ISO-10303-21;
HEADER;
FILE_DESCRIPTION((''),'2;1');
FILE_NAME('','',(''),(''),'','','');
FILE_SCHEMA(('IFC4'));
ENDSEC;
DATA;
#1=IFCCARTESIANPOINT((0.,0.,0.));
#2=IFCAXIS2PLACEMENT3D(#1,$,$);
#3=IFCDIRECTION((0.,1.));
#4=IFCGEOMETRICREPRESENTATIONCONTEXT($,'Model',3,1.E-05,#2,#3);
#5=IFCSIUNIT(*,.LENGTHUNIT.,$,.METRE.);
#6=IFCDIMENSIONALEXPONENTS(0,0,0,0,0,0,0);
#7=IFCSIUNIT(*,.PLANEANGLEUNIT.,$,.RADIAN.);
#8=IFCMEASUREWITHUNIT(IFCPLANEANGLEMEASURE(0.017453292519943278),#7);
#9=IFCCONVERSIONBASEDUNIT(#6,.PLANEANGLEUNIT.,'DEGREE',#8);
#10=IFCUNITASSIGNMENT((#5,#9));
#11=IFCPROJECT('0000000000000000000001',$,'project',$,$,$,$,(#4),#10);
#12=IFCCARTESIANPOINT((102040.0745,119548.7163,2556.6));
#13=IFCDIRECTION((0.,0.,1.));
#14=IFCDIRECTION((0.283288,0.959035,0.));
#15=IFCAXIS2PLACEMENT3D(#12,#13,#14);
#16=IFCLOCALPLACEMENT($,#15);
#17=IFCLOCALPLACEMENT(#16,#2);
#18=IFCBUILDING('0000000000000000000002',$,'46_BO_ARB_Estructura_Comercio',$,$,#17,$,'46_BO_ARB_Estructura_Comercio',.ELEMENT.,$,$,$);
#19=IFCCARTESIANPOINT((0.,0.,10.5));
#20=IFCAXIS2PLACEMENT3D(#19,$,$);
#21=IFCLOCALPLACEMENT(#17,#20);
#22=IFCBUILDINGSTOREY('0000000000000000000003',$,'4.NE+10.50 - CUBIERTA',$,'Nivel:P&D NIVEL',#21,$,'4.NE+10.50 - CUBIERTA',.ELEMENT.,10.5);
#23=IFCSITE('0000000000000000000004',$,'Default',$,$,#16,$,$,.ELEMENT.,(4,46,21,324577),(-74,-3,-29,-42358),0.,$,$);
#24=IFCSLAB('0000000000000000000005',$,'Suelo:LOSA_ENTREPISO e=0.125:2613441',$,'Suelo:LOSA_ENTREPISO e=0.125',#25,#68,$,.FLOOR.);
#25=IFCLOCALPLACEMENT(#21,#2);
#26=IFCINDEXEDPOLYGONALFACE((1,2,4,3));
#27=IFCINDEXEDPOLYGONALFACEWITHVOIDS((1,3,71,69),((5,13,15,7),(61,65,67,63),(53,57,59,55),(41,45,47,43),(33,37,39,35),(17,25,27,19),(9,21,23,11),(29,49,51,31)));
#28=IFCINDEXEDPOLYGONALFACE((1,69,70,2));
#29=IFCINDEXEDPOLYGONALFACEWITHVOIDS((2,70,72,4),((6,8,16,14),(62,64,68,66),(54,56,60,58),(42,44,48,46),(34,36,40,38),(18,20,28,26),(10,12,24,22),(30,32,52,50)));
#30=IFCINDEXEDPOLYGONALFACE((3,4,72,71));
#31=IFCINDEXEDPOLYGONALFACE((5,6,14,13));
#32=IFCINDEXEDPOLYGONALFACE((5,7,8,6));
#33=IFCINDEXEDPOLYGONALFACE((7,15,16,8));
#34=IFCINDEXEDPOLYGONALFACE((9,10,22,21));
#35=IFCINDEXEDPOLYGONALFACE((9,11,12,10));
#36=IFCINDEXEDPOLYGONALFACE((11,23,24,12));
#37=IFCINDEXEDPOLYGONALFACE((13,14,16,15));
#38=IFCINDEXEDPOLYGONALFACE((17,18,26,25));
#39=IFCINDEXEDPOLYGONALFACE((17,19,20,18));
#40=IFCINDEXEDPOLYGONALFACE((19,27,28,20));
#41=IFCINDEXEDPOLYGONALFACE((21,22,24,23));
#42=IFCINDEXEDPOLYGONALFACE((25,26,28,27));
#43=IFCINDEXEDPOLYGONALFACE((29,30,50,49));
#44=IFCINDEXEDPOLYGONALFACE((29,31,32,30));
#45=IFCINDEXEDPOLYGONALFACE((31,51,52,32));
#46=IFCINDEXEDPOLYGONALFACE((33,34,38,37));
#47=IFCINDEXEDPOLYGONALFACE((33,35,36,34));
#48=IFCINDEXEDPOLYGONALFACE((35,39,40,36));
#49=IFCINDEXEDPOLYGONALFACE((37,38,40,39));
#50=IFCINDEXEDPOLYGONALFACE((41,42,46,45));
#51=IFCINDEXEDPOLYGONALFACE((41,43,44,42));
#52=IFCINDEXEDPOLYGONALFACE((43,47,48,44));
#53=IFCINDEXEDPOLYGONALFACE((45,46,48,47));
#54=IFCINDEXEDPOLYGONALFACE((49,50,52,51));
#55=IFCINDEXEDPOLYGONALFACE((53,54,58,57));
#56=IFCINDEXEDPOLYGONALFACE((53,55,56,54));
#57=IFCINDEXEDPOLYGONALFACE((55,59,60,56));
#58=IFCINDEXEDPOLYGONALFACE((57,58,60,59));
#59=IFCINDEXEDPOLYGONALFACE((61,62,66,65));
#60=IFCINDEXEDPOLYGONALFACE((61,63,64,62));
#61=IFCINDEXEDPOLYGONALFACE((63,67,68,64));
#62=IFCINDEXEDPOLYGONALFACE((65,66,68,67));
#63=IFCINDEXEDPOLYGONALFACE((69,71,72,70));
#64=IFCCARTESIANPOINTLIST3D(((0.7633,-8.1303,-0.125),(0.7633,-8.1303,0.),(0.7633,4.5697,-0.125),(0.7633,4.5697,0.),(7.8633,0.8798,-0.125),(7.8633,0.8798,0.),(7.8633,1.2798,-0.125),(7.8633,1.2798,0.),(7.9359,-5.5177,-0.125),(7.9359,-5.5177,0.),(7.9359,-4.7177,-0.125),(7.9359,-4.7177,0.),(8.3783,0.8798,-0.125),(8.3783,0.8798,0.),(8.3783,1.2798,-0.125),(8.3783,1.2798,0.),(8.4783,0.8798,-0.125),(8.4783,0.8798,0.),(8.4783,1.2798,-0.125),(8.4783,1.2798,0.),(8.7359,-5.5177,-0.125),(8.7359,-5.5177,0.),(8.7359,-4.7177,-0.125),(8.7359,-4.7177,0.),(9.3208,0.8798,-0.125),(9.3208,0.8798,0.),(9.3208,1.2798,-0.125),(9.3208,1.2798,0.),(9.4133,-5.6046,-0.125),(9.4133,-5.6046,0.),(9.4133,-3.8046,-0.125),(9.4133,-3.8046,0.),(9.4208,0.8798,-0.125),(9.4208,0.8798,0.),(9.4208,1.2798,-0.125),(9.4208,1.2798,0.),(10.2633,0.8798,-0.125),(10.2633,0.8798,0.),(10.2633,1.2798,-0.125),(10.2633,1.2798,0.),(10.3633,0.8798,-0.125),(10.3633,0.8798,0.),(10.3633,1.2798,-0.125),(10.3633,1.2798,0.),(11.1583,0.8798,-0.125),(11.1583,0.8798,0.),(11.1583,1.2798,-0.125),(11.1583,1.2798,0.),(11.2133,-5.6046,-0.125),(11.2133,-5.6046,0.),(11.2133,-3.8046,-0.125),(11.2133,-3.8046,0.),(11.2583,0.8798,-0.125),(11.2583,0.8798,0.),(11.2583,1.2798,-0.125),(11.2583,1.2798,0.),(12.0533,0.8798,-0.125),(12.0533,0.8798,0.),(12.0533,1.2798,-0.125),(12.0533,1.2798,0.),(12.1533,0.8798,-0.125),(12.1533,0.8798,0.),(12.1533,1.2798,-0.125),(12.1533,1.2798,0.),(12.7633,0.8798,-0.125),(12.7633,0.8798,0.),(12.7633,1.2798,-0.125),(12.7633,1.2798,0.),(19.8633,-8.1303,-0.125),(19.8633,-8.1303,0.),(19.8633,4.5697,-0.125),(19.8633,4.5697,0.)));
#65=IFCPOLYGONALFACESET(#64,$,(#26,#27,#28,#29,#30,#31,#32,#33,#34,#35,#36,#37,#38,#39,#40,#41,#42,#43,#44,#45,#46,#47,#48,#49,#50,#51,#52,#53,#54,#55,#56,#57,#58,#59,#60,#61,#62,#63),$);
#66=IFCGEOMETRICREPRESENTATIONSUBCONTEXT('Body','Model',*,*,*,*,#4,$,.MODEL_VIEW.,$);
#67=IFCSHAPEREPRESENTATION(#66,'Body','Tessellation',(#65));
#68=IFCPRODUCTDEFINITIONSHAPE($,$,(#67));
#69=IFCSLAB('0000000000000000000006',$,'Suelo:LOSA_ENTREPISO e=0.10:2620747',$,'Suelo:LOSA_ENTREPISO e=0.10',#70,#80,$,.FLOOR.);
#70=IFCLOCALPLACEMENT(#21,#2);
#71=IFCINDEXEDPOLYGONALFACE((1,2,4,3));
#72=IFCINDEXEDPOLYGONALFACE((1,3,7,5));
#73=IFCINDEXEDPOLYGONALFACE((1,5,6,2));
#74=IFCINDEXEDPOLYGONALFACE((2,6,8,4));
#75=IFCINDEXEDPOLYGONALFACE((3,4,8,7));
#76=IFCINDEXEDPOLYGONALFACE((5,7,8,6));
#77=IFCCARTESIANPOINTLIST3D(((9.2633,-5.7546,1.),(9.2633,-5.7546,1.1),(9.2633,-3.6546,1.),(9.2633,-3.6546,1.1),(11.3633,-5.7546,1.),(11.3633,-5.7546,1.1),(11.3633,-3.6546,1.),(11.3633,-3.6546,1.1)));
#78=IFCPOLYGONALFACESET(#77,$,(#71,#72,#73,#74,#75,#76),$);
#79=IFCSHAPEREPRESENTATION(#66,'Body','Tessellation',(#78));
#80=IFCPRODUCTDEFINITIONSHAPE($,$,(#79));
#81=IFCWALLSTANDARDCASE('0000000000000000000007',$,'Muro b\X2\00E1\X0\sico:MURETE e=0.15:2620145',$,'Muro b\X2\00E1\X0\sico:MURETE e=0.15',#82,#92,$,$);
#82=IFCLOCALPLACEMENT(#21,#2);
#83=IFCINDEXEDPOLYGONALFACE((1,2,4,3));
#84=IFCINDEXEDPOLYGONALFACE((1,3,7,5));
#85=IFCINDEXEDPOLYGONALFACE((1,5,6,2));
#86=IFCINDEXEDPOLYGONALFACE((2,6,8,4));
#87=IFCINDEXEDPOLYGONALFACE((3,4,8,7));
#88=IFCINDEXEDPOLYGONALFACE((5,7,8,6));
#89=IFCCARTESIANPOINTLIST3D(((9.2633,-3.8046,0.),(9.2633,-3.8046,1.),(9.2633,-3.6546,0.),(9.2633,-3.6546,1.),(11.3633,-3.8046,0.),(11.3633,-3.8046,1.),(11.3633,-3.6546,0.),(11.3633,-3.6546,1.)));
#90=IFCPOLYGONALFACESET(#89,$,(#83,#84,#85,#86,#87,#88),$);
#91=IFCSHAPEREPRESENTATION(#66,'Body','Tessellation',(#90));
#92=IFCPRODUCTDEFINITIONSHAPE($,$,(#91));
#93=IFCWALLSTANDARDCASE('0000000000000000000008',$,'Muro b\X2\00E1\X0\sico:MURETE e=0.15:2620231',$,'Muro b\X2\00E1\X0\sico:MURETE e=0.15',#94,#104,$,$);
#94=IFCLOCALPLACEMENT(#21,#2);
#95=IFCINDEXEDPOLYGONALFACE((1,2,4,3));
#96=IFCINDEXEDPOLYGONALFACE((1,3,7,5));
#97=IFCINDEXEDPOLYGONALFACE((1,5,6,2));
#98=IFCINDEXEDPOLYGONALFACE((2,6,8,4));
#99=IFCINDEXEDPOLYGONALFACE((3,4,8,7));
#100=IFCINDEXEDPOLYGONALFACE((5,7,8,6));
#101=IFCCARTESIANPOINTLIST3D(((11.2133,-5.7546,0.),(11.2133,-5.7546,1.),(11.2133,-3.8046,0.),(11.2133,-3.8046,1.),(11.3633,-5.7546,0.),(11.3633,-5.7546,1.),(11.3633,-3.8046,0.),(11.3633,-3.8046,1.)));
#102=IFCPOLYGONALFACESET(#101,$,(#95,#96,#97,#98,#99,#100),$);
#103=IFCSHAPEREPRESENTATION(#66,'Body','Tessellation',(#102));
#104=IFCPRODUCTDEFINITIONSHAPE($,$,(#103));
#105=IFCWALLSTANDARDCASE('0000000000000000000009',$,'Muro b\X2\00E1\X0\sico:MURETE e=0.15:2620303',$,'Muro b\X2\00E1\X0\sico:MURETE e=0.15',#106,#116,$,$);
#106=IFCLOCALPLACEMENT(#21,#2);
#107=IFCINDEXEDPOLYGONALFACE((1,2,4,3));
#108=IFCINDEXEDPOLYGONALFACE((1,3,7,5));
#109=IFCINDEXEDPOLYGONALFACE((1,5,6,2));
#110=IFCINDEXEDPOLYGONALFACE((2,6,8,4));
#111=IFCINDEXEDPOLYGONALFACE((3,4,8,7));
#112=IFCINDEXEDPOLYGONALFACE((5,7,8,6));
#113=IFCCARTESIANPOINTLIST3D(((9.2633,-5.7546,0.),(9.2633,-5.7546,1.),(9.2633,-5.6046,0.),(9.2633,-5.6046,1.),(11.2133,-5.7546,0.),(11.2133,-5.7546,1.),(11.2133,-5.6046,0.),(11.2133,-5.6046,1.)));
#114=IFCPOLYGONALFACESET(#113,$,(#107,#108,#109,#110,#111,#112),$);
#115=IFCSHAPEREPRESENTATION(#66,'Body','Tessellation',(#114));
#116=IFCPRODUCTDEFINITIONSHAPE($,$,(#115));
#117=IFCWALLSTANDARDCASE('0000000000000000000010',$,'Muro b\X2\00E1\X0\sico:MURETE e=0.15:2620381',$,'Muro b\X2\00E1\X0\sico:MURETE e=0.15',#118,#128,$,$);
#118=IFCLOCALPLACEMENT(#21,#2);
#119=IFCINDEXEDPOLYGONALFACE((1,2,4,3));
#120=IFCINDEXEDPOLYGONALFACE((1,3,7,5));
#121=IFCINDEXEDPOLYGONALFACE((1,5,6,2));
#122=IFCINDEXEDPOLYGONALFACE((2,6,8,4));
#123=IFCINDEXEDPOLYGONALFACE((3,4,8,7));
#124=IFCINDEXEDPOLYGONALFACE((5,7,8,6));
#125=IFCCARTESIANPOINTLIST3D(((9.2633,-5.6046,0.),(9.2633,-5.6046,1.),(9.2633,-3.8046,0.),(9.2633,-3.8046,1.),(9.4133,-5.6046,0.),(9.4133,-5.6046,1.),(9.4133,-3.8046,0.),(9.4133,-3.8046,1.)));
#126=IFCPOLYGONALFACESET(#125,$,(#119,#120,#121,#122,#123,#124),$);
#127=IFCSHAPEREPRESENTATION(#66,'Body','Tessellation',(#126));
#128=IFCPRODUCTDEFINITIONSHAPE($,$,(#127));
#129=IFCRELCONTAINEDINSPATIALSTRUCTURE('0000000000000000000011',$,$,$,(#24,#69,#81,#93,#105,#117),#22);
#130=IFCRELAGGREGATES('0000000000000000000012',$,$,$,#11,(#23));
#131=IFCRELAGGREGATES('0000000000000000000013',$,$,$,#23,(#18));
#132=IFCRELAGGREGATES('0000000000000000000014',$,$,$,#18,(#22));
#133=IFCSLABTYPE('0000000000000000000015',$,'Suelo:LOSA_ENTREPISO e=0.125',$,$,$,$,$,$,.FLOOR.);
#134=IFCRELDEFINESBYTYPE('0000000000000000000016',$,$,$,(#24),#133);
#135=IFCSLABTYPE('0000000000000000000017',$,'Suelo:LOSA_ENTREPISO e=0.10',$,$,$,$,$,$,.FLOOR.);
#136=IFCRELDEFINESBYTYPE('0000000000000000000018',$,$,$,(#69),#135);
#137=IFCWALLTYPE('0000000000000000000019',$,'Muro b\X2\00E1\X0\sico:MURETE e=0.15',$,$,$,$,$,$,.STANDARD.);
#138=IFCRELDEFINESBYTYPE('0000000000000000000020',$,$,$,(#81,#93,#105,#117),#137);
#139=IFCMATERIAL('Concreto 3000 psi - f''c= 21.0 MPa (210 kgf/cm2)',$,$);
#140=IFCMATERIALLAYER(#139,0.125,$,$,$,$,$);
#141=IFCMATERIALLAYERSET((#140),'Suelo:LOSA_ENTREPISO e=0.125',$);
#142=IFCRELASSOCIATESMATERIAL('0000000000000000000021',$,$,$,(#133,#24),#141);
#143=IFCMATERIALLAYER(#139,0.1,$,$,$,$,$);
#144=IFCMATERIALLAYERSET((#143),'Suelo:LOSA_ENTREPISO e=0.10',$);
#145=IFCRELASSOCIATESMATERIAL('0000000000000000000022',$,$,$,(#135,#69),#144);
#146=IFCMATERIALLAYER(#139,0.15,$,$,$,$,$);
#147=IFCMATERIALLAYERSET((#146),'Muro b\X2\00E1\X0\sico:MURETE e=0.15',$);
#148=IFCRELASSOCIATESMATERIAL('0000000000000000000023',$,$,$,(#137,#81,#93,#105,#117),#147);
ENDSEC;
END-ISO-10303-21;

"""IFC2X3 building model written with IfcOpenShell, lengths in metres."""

from ifc_helpers import new_model, entity, si_unit, converted_unit, direction, frame, frame_2d, origin, origin_2d_with_axis, place, context, subcontext, project, spatial, rectangle, extrude, boolean, material, layer, layer_set, layer_usage, type_object, element, save


model = new_model("IFC2X3")

# Units and contexts
model_context = context("Model", 3, precision=1e-05, world=origin(), true_north=direction((0.0, 1.0)))
body_context = subcontext(model_context, "Body", "Model", "MODEL_VIEW")
ifc_project = project(units=[si_unit("LENGTHUNIT", "METRE"), converted_unit("PLANEANGLEUNIT", "DEGREE", entity("IfcPlaneAngleMeasure", 0.017453292519943278), si_unit("PLANEANGLEUNIT", "RADIAN"), dimensions=[0, 0, 0, 0, 0, 0, 0])], contexts=[model_context])

# Site, building, storey
site_placement = place(None, frame((102040.0745, 119548.7163, 2556.6), z_axis=(0.0, 0.0, 1.0), x_axis=(0.283288, 0.959035, 0.0)))
site = spatial("IfcSite", under=ifc_project, at=site_placement, Name="Default", CompositionType="ELEMENT", RefLatitude=(4, 46, 21, 324577), RefLongitude=(-74, -3, -29, -42358), RefElevation=0.0)
building_placement = place(site_placement, origin())
building = spatial("IfcBuilding", under=site, at=building_placement, Name="46_BO_ARB_Estructura_Comercio", LongName="46_BO_ARB_Estructura_Comercio", CompositionType="ELEMENT")
storey_placement = place(building_placement, frame((0.0, 0.0, 10.5)))
storey = spatial("IfcBuildingStorey", under=building, at=storey_placement, Name="4.NE+10.50 - CUBIERTA", ObjectType="Nivel:P&D NIVEL", LongName="4.NE+10.50 - CUBIERTA", CompositionType="ELEMENT", Elevation=10.5)

# Shared definitions
ifc_material = material(Name="Concreto 3000 psi - f'c= 21.0 MPa (210 kgf/cm2)")

# Slab, openings
ifc_layer_1 = layer(ifc_material, 0.125)
ifc_layer_set_1 = layer_set([ifc_layer_1], Name="Suelo:LOSA_ENTREPISO e=0.125")
ifc_layer_usage_1 = layer_usage(ifc_layer_set_1, "AXIS3", "POSITIVE", 0.0)
slab_type_1 = type_object("IfcSlabType", Name="Suelo:LOSA_ENTREPISO e=0.125", PredefinedType="FLOOR", material=ifc_layer_set_1)
slab_1_placement = place(storey_placement, origin())
slab_1 = element("IfcSlab", 1, at=slab_1_placement, inside=storey, type_object=slab_type_1, material=ifc_layer_usage_1, Name="Suelo:LOSA_ENTREPISO e=0.125:2613441", ObjectType="Suelo:LOSA_ENTREPISO e=0.125", PredefinedType="FLOOR", context=body_context, shape_type="SweptSolid", body=[
    boolean("DIFFERENCE", boolean("DIFFERENCE", boolean("DIFFERENCE", boolean("DIFFERENCE", boolean("DIFFERENCE", boolean("DIFFERENCE", boolean("DIFFERENCE", boolean("DIFFERENCE", extrude(rectangle(XDim=12.7, YDim=19.1, at=origin_2d_with_axis()), frame((10.3133, -1.7803, 0.0), z_axis=(0.0, 0.0, -1.0), x_axis=(0.0, 1.0, 0.0)), (0.0, 0.0, 1.0), 0.125), extrude(rectangle(XDim=0.4, YDim=0.515, at=origin_2d_with_axis()), frame((8.1208, 1.0798, -0.125), z_axis=(0.0, 0.0, 1.0), x_axis=(0.0, 1.0, 0.0)), (0.0, 0.0, 1.0), 0.125)), extrude(rectangle(XDim=0.4, YDim=0.8425, at=origin_2d_with_axis()), frame((8.8995, 1.0798, -0.125), z_axis=(0.0, 0.0, 1.0), x_axis=(0.0, 1.0, 0.0)), (0.0, 0.0, 1.0), 0.125)), extrude(rectangle(XDim=0.4, YDim=0.8425, at=origin_2d_with_axis()), frame((9.842, 1.0798, -0.125), z_axis=(0.0, 0.0, 1.0), x_axis=(0.0, 1.0, 0.0)), (0.0, 0.0, 1.0), 0.125)), extrude(rectangle(XDim=0.4, YDim=0.795, at=frame_2d((0.0, 0.0), x_axis=(1.0, 0.0))), frame((10.7608, 1.0798, -0.125), z_axis=(0.0, 0.0, 1.0), x_axis=(0.0, 1.0, 0.0)), (0.0, 0.0, 1.0), 0.125)), extrude(rectangle(XDim=1.8, YDim=1.8, at=origin_2d_with_axis()), frame((10.3133, -4.7046, -0.125), z_axis=(0.0, 0.0, 1.0), x_axis=(0.0, 1.0, 0.0)), (0.0, 0.0, 1.0), 0.125)), extrude(rectangle(XDim=0.4, YDim=0.795, at=frame_2d((0.0, 0.0), x_axis=(1.0, 0.0))), frame((11.6558, 1.0798, -0.125), z_axis=(0.0, 0.0, 1.0), x_axis=(0.0, 1.0, 0.0)), (0.0, 0.0, 1.0), 0.125)), extrude(rectangle(XDim=0.4, YDim=0.61, at=frame_2d((0.0, 0.0), x_axis=(1.0, 0.0))), frame((12.4583, 1.0798, -0.125), z_axis=(0.0, 0.0, 1.0), x_axis=(0.0, 1.0, 0.0)), (0.0, 0.0, 1.0), 0.125)), extrude(rectangle(XDim=0.8, YDim=0.8, at=origin_2d_with_axis()), frame((8.3359, -5.1177, -0.125), z_axis=(0.0, 0.0, 1.0), x_axis=(0.0, 1.0, 0.0)), (0.0, 0.0, 1.0), 0.125)),
])
opening_1_placement = place(slab_1_placement, origin())
element("IfcOpeningElement", 2, at=opening_1_placement, cuts=slab_1, ObjectType="Opening", context=body_context, shape_type="SweptSolid", body=[
    extrude(rectangle(XDim=0.515, YDim=0.4, at=origin_2d_with_axis()), frame((8.1208, 1.0798, 0.0), z_axis=(0.0, 0.0, -1.0), x_axis=(-1.0, 0.0, 0.0)), (0.0, 0.0, 1.0), 0.125),
])
opening_2_placement = place(slab_1_placement, origin())
element("IfcOpeningElement", 3, at=opening_2_placement, cuts=slab_1, ObjectType="Opening", context=body_context, shape_type="SweptSolid", body=[
    extrude(rectangle(XDim=0.4, YDim=0.8425, at=frame_2d((0.0, 0.0), x_axis=(1.0, 0.0))), frame((8.8995, 1.0798, 0.0), z_axis=(0.0, 0.0, -1.0), x_axis=(0.0, -1.0, 0.0)), (0.0, 0.0, 1.0), 0.125),
])
opening_3_placement = place(slab_1_placement, origin())
element("IfcOpeningElement", 4, at=opening_3_placement, cuts=slab_1, ObjectType="Opening", context=body_context, shape_type="SweptSolid", body=[
    extrude(rectangle(XDim=0.4, YDim=0.8425, at=origin_2d_with_axis()), frame((9.842, 1.0798, 0.0), z_axis=(0.0, 0.0, -1.0), x_axis=(0.0, -1.0, 0.0)), (0.0, 0.0, 1.0), 0.125),
])
opening_4_placement = place(slab_1_placement, origin())
element("IfcOpeningElement", 5, at=opening_4_placement, cuts=slab_1, ObjectType="Opening", context=body_context, shape_type="SweptSolid", body=[
    extrude(rectangle(XDim=0.4, YDim=0.795, at=frame_2d((0.0, 0.0), x_axis=(1.0, 0.0))), frame((10.7608, 1.0798, 0.0), z_axis=(0.0, 0.0, -1.0), x_axis=(0.0, -1.0, 0.0)), (0.0, 0.0, 1.0), 0.125),
])
opening_5_placement = place(slab_1_placement, origin())
element("IfcOpeningElement", 6, at=opening_5_placement, cuts=slab_1, ObjectType="Opening", context=body_context, shape_type="SweptSolid", body=[
    extrude(rectangle(XDim=0.4, YDim=0.795, at=frame_2d((0.0, 0.0), x_axis=(1.0, 0.0))), frame((11.6558, 1.0798, 0.0), z_axis=(0.0, 0.0, -1.0), x_axis=(0.0, -1.0, 0.0)), (0.0, 0.0, 1.0), 0.125),
])
opening_6_placement = place(slab_1_placement, origin())
element("IfcOpeningElement", 7, at=opening_6_placement, cuts=slab_1, ObjectType="Opening", context=body_context, shape_type="SweptSolid", body=[
    extrude(rectangle(XDim=0.4, YDim=0.61, at=frame_2d((0.0, 0.0), x_axis=(1.0, 0.0))), frame((12.4583, 1.0798, 0.0), z_axis=(0.0, 0.0, -1.0), x_axis=(0.0, -1.0, 0.0)), (0.0, 0.0, 1.0), 0.125),
])
opening_7_placement = place(slab_1_placement, origin())
element("IfcOpeningElement", 8, at=opening_7_placement, cuts=slab_1, ObjectType="Opening", context=body_context, shape_type="SweptSolid", body=[
    extrude(rectangle(XDim=1.8, YDim=1.8, at=frame_2d((0.0, 0.0), x_axis=(1.0, 0.0))), frame((10.3133, -4.7046, 0.0), z_axis=(0.0, 0.0, -1.0), x_axis=(0.0, -1.0, 0.0)), (0.0, 0.0, 1.0), 0.125),
])
opening_8_placement = place(slab_1_placement, origin())
element("IfcOpeningElement", 9, at=opening_8_placement, cuts=slab_1, ObjectType="Opening", context=body_context, shape_type="SweptSolid", body=[
    extrude(rectangle(XDim=0.8, YDim=0.8, at=origin_2d_with_axis()), frame((8.3359, -5.1177, 0.0), z_axis=(0.0, 0.0, -1.0), x_axis=(0.0, -1.0, 0.0)), (0.0, 0.0, 1.0), 0.125),
])

# Slab
ifc_layer_2 = layer(ifc_material, 0.1)
ifc_layer_set_2 = layer_set([ifc_layer_2], Name="Suelo:LOSA_ENTREPISO e=0.10")
ifc_layer_usage_2 = layer_usage(ifc_layer_set_2, "AXIS3", "POSITIVE", 0.0)
slab_type_2 = type_object("IfcSlabType", Name="Suelo:LOSA_ENTREPISO e=0.10", PredefinedType="FLOOR", material=ifc_layer_set_2)
slab_2_placement = place(storey_placement, origin())
element("IfcSlab", 10, at=slab_2_placement, inside=storey, type_object=slab_type_2, material=ifc_layer_usage_2, Name="Suelo:LOSA_ENTREPISO e=0.10:2620747", ObjectType="Suelo:LOSA_ENTREPISO e=0.10", PredefinedType="FLOOR", context=body_context, shape_type="SweptSolid", body=[
    extrude(rectangle(XDim=2.1, YDim=2.1, at=frame_2d((0.0, 0.0), x_axis=(1.0, 0.0))), frame((10.3133, -4.7046, 1.1), z_axis=(0.0, 0.0, -1.0), x_axis=(0.0, 1.0, 0.0)), (0.0, 0.0, 1.0), 0.1),
])

# Walls
ifc_layer_3 = layer(ifc_material, 0.15)
ifc_layer_set_3 = layer_set([ifc_layer_3], Name="Muro básico:MURETE e=0.15")
ifc_layer_usage_3 = layer_usage(ifc_layer_set_3, "AXIS2", "NEGATIVE", 0.075)
wall_type = type_object("IfcWallType", Name="Muro básico:MURETE e=0.15", PredefinedType="STANDARD", material=ifc_layer_set_3)
wall_1_placement = place(storey_placement, frame((9.2633, -3.7296, 0.0)))
element("IfcWallStandardCase", 11, at=wall_1_placement, inside=storey, type_object=wall_type, material=ifc_layer_usage_3, Name="Muro básico:MURETE e=0.15:2620145", ObjectType="Muro básico:MURETE e=0.15", context=body_context, shape_type="SweptSolid", body=[
    extrude(rectangle(XDim=2.1, YDim=0.15, at=frame_2d((1.05, 0.0), x_axis=(-1.0, 0.0))), origin(), (0.0, 0.0, 1.0), 1.0),
])
ifc_layer_usage_4 = layer_usage(ifc_layer_set_3, "AXIS2", "NEGATIVE", 0.075)
wall_2_placement = place(storey_placement, frame((11.2883, -3.8046, 0.0), z_axis=(0.0, 0.0, 1.0), x_axis=(0.0, -1.0, 0.0)))
element("IfcWallStandardCase", 12, at=wall_2_placement, inside=storey, type_object=wall_type, material=ifc_layer_usage_4, Name="Muro básico:MURETE e=0.15:2620231", ObjectType="Muro básico:MURETE e=0.15", context=body_context, shape_type="SweptSolid", body=[
    extrude(rectangle(XDim=1.95, YDim=0.15, at=frame_2d((0.975, 0.0), x_axis=(-1.0, 0.0))), origin(), (0.0, 0.0, 1.0), 1.0),
])
ifc_layer_usage_5 = layer_usage(ifc_layer_set_3, "AXIS2", "NEGATIVE", 0.075)
wall_3_placement = place(storey_placement, frame((11.2133, -5.6796, 0.0), z_axis=(0.0, 0.0, 1.0), x_axis=(-1.0, 0.0, 0.0)))
element("IfcWallStandardCase", 13, at=wall_3_placement, inside=storey, type_object=wall_type, material=ifc_layer_usage_5, Name="Muro básico:MURETE e=0.15:2620303", ObjectType="Muro básico:MURETE e=0.15", context=body_context, shape_type="SweptSolid", body=[
    extrude(rectangle(XDim=1.95, YDim=0.15, at=frame_2d((0.975, 0.0), x_axis=(-1.0, 0.0))), origin(), (0.0, 0.0, 1.0), 1.0),
])
ifc_layer_usage_6 = layer_usage(ifc_layer_set_3, "AXIS2", "NEGATIVE", 0.075)
wall_4_placement = place(storey_placement, frame((9.3383, -5.6046, 0.0), z_axis=(0.0, 0.0, 1.0), x_axis=(0.0, 1.0, 0.0)))
element("IfcWallStandardCase", 14, at=wall_4_placement, inside=storey, type_object=wall_type, material=ifc_layer_usage_6, Name="Muro básico:MURETE e=0.15:2620381", ObjectType="Muro básico:MURETE e=0.15", context=body_context, shape_type="SweptSolid", body=[
    extrude(rectangle(XDim=1.8, YDim=0.15, at=frame_2d((0.9, 0.0), x_axis=(-1.0, 0.0))), origin(), (0.0, 0.0, 1.0), 1.0),
])

save(model, "model.ifc")
